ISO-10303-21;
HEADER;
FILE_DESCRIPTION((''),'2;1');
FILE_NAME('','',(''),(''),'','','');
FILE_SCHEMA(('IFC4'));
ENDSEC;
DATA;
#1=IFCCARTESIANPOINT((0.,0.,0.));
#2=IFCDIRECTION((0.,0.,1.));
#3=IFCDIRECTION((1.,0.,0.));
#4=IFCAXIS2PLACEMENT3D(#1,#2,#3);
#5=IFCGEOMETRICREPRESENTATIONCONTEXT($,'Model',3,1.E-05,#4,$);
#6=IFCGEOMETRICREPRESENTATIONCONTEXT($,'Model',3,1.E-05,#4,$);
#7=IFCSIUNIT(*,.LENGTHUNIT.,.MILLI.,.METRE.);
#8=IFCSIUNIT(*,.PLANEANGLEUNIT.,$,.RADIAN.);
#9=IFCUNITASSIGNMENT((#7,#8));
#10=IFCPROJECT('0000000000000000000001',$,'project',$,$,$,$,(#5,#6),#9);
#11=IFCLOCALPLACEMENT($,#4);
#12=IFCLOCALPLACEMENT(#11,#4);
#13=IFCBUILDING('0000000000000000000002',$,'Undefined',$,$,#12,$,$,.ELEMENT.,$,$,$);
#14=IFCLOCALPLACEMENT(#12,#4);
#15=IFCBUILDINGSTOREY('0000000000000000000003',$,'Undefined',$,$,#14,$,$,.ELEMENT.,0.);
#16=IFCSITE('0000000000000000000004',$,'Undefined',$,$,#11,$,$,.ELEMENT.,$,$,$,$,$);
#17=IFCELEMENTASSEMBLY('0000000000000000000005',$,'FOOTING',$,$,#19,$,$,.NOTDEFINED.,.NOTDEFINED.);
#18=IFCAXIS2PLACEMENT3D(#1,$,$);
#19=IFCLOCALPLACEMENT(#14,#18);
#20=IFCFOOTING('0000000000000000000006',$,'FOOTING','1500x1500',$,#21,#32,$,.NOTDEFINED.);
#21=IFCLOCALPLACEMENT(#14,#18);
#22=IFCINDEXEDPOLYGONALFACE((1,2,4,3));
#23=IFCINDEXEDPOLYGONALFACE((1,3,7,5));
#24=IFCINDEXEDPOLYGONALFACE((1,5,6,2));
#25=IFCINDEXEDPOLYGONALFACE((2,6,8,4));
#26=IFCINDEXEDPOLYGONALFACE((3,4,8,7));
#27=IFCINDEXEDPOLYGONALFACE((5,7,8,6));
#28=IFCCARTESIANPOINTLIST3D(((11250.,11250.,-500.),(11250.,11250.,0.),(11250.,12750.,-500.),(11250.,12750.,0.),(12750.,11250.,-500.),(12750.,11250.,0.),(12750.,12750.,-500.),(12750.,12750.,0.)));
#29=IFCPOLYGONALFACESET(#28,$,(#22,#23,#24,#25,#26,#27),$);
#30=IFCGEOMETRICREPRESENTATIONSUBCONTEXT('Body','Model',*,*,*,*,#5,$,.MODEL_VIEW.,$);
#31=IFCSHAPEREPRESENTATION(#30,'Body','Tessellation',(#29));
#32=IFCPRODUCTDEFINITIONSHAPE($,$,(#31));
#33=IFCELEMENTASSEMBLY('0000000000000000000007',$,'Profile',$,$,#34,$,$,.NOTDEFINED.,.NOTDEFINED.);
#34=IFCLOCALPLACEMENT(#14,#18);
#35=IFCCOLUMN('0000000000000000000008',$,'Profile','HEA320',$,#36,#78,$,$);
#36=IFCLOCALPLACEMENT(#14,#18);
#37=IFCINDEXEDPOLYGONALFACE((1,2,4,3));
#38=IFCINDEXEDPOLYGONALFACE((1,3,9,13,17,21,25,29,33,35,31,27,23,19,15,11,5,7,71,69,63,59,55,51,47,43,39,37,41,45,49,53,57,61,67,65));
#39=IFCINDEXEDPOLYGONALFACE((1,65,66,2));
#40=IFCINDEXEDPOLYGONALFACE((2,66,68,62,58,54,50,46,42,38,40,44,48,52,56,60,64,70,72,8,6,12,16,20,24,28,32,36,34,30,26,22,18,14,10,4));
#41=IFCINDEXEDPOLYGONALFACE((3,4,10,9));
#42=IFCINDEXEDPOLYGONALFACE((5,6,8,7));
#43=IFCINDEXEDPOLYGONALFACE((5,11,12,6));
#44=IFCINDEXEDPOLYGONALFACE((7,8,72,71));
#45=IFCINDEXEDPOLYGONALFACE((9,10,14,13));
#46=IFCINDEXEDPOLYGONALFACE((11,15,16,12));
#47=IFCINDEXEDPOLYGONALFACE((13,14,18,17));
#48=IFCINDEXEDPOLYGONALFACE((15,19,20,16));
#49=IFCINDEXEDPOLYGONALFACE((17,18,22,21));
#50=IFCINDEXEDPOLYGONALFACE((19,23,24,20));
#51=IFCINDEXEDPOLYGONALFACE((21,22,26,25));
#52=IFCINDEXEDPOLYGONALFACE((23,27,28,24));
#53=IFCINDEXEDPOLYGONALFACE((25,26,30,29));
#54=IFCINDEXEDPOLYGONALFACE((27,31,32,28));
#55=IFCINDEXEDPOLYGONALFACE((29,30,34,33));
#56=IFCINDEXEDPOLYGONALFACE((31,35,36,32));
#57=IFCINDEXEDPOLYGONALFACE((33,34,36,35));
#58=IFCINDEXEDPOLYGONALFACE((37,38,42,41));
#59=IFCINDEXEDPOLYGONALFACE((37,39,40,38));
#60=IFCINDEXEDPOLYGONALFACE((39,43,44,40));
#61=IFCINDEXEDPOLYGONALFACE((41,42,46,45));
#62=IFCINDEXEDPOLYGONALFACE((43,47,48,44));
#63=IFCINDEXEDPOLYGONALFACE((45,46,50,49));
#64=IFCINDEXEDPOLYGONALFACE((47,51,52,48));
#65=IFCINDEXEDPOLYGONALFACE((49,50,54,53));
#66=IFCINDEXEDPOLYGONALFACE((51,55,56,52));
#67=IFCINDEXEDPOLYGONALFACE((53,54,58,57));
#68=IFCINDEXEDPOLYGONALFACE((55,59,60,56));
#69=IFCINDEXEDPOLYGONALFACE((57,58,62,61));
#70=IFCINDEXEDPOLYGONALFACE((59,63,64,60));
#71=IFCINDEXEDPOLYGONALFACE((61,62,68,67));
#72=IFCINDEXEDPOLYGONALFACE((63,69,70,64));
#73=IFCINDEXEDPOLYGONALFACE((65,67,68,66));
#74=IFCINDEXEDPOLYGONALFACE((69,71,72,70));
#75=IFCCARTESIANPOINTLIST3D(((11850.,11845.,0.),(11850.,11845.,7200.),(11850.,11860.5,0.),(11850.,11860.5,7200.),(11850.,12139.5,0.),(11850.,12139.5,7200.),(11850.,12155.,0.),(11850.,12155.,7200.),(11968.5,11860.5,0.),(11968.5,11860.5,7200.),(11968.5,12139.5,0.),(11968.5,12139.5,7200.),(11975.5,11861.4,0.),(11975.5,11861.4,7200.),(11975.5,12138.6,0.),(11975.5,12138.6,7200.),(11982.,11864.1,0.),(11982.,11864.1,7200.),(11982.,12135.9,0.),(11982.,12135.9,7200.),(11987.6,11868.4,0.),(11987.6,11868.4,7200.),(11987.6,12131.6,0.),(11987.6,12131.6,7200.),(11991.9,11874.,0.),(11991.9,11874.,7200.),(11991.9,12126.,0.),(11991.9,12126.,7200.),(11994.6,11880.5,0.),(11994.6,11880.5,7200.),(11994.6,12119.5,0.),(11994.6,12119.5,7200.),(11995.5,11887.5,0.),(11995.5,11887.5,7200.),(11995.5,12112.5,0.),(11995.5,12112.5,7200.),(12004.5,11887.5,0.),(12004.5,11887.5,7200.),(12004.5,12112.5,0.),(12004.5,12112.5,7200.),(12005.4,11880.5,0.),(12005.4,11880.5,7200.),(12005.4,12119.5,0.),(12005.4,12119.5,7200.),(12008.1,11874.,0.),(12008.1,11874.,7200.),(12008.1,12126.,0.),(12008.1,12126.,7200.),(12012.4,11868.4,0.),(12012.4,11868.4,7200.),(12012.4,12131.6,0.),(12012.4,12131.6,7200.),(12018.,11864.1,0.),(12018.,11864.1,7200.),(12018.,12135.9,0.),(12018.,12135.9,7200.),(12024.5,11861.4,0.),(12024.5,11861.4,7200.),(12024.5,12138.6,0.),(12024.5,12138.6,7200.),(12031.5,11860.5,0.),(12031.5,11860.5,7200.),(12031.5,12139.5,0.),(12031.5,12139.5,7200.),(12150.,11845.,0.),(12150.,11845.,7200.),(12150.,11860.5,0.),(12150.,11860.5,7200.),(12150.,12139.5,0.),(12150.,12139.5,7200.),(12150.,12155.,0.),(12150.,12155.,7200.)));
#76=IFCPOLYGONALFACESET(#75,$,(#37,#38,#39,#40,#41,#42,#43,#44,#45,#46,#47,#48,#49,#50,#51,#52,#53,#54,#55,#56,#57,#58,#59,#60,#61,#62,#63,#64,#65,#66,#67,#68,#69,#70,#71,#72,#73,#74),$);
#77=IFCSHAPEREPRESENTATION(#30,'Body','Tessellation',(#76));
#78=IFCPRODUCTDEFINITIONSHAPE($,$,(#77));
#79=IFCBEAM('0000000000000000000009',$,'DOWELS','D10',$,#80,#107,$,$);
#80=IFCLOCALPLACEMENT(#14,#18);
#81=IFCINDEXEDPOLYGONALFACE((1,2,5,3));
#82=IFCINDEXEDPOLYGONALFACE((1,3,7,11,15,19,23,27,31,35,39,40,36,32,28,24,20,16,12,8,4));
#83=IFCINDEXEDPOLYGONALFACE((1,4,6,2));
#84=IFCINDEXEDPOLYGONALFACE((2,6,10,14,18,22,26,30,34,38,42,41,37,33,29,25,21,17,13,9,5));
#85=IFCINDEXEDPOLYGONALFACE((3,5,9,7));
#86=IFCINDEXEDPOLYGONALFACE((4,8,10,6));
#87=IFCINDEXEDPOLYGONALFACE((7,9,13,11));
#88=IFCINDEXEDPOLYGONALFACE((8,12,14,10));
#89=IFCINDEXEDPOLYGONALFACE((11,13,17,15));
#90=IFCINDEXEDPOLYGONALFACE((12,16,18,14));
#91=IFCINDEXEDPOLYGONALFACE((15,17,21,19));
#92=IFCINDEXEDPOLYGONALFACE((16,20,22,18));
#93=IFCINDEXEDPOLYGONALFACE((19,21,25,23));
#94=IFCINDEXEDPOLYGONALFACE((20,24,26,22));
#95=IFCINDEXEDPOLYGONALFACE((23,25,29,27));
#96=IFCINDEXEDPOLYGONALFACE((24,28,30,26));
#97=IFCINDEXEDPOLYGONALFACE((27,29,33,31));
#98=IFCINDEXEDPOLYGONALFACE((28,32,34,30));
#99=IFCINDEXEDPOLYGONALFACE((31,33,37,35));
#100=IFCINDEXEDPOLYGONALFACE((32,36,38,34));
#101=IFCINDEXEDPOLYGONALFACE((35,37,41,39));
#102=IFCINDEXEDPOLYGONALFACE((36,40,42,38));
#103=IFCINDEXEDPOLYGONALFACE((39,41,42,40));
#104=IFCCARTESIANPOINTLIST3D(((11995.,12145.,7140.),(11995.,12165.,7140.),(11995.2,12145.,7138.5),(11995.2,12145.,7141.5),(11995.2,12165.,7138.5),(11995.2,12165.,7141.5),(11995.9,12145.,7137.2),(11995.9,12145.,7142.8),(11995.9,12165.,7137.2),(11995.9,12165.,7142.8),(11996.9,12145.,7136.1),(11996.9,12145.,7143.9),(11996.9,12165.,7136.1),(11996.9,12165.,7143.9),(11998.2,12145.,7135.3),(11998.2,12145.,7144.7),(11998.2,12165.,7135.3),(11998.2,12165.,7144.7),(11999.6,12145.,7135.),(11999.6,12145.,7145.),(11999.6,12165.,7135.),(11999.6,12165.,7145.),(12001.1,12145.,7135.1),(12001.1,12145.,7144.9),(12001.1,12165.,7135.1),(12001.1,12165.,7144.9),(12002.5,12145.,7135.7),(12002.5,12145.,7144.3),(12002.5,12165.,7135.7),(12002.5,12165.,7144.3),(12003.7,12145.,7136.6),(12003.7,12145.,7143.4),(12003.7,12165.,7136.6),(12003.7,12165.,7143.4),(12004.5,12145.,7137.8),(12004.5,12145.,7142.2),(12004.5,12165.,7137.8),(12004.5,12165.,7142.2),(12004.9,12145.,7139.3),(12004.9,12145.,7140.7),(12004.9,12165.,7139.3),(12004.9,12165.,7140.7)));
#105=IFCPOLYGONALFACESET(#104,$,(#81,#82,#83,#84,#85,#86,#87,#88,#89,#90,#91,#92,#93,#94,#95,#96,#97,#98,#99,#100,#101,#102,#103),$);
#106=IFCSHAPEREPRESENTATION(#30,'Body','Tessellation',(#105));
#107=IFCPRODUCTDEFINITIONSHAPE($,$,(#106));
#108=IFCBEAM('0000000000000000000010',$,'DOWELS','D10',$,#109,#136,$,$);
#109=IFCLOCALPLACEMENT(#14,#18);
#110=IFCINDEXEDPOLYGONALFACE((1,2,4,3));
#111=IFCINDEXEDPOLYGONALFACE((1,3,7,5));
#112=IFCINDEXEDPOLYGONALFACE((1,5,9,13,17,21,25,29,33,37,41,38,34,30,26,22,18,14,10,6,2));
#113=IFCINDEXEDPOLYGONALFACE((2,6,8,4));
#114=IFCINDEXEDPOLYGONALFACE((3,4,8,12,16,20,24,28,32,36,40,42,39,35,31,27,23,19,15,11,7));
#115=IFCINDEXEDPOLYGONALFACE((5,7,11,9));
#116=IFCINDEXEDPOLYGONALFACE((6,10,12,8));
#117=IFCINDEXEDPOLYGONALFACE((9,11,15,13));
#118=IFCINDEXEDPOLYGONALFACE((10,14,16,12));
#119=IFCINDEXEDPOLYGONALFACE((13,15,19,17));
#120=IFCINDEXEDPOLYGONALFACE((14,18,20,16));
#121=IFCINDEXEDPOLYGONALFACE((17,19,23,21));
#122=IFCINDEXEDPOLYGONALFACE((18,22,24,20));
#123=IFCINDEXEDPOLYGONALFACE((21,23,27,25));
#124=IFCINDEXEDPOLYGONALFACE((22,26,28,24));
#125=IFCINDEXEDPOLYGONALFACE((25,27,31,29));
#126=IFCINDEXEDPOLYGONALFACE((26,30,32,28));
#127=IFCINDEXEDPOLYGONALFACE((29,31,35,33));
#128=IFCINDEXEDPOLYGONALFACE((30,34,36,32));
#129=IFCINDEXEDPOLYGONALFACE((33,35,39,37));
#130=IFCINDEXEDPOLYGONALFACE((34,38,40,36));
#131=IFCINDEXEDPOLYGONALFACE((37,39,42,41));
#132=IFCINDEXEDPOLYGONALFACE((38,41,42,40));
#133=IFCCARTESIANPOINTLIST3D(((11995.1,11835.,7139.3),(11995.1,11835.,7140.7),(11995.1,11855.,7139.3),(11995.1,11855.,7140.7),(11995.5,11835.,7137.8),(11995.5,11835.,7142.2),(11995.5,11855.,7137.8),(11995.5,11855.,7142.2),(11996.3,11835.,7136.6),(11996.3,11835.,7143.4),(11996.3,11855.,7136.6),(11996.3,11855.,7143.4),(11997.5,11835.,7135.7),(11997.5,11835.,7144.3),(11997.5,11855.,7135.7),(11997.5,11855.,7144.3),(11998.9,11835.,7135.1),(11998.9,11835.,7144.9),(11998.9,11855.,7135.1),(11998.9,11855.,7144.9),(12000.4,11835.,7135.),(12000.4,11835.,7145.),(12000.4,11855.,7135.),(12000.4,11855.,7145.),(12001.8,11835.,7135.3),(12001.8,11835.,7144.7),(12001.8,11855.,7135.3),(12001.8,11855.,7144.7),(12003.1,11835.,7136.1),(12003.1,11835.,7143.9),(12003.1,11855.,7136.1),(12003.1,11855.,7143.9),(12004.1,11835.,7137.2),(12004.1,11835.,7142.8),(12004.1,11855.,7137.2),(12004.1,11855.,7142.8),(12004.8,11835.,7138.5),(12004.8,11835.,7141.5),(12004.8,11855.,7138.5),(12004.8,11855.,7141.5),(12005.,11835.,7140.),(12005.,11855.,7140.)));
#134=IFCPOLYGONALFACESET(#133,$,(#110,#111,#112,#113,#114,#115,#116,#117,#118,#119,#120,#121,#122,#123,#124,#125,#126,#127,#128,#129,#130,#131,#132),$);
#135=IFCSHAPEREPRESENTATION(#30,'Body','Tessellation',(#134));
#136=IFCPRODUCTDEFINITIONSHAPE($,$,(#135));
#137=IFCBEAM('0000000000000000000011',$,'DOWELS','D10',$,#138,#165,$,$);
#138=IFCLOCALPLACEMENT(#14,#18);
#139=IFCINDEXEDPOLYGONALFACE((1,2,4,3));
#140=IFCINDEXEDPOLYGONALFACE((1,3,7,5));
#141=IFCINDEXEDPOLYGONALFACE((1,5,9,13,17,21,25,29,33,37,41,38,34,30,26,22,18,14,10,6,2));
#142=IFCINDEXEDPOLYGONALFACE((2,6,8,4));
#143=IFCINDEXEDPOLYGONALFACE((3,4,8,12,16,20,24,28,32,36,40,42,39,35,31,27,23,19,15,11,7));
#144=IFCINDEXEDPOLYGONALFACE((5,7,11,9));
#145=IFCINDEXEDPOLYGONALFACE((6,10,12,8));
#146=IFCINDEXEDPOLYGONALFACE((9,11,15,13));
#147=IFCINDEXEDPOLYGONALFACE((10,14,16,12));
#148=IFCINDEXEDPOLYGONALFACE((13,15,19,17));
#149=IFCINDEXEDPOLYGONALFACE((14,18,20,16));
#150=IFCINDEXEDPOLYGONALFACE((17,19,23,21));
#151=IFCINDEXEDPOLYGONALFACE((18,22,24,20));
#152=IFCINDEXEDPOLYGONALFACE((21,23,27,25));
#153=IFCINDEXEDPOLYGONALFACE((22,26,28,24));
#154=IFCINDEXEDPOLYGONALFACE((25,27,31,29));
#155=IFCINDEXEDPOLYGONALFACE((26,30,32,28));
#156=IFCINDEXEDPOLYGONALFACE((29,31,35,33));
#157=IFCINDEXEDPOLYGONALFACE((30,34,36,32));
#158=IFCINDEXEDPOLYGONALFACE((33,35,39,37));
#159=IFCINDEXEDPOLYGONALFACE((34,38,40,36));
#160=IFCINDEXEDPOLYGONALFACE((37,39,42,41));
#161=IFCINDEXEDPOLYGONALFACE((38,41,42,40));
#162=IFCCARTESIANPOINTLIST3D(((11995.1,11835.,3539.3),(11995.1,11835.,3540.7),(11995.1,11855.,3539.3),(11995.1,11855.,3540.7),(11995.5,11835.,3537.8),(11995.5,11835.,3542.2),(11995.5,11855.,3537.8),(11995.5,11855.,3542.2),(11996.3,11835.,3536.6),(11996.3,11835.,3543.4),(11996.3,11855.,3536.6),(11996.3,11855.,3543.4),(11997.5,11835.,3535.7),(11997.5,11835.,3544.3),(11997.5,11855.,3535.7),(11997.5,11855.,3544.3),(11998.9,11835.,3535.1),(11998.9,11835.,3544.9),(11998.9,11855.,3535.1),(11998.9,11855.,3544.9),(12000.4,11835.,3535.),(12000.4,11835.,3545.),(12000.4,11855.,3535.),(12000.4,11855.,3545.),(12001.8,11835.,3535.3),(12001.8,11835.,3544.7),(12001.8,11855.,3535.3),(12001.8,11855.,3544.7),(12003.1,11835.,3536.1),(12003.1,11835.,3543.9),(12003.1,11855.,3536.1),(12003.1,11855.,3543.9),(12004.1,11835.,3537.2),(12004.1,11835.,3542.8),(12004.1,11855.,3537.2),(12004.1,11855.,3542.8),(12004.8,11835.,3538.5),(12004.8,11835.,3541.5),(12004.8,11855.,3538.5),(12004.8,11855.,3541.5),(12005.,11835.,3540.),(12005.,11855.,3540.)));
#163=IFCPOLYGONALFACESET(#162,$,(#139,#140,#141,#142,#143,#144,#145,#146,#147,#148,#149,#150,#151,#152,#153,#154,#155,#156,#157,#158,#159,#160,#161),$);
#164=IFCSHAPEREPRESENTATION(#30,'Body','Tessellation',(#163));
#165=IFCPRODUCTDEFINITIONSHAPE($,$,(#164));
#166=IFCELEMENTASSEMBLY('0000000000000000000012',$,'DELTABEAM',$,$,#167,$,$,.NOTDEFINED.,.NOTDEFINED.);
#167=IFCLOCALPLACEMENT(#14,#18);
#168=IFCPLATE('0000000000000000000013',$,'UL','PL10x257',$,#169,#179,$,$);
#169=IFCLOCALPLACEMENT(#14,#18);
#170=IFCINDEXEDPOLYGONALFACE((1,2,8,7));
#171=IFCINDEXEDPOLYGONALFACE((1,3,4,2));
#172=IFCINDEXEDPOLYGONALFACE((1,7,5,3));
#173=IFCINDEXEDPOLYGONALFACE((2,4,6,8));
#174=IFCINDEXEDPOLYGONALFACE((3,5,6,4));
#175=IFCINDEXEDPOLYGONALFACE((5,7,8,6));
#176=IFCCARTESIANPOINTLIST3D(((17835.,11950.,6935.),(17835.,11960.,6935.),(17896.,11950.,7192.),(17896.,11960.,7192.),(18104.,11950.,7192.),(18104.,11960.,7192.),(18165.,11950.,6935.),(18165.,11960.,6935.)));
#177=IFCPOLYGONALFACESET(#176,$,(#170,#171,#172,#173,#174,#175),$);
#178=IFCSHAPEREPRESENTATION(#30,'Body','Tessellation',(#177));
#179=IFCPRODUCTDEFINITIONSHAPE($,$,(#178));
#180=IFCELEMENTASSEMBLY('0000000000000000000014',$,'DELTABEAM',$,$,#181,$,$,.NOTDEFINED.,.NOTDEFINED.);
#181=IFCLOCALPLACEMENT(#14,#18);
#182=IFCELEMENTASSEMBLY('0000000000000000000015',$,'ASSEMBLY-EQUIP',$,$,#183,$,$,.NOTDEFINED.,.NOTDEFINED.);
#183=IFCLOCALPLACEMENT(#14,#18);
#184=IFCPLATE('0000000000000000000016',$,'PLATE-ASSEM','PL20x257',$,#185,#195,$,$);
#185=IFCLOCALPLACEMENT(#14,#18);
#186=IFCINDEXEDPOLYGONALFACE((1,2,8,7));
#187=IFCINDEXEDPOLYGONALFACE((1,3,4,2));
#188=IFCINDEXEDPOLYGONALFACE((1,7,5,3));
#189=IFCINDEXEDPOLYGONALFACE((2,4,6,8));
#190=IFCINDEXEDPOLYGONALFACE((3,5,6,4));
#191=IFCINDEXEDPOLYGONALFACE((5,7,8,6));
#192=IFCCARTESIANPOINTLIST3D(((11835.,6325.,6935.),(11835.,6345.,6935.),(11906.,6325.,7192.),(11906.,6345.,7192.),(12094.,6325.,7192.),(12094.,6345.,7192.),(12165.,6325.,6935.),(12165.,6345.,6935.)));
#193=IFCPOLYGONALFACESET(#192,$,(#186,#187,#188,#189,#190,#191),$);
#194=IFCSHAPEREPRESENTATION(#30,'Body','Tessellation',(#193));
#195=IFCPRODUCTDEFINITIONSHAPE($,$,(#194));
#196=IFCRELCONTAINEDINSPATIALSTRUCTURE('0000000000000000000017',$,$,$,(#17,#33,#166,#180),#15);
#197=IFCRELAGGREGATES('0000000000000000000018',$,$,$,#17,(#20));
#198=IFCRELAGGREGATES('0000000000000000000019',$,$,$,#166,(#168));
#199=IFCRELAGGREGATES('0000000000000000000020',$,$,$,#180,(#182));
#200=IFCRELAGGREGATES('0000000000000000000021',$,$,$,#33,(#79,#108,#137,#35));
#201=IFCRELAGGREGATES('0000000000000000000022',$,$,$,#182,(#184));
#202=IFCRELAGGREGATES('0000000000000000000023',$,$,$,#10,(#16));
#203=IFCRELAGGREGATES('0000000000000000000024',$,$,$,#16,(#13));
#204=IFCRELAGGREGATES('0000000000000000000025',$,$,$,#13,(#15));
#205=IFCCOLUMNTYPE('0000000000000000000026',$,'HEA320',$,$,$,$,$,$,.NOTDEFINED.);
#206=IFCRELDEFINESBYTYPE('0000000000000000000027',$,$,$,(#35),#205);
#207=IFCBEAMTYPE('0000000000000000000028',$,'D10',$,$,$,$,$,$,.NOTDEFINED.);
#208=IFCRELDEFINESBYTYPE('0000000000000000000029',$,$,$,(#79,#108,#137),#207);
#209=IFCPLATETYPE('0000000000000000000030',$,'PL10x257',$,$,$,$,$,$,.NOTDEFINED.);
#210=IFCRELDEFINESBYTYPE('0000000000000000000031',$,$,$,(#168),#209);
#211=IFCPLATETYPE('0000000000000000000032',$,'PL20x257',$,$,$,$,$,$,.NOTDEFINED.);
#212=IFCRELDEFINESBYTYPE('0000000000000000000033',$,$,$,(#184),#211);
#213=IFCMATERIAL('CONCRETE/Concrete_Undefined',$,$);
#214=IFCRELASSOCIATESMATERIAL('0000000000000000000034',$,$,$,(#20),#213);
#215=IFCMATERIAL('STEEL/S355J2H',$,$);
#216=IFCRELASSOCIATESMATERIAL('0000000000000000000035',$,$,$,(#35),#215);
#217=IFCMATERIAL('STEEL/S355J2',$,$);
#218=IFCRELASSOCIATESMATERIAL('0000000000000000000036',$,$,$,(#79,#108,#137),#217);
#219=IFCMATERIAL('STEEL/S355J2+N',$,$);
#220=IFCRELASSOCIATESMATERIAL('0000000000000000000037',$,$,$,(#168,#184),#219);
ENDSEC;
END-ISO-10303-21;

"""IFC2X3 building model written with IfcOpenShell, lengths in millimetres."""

from ifc_helpers import new_model, si_unit, frame, origin_with_axes, origin_2d_with_axis, place, context, subcontext, project, spatial, polyline, rectangle, circle, i_section, outline, extrude, material, type_object, element, aggregate, save


model = new_model("IFC2X3")

# Units and contexts
model_context_1 = context("Model", 3, precision=1e-05, world=origin_with_axes())
model_context_2 = context("Model", 3, precision=1e-05, world=origin_with_axes())
body_context = subcontext(model_context_1, "Body", "Model", "MODEL_VIEW")
ifc_project = project(units=[si_unit("LENGTHUNIT", "METRE", prefix="MILLI"), si_unit("PLANEANGLEUNIT", "RADIAN")], contexts=[model_context_1, model_context_2])

# Site, building, storey
site_placement = place(None, origin_with_axes())
site = spatial("IfcSite", under=ifc_project, at=site_placement, Name="Undefined", CompositionType="ELEMENT")
building_placement = place(site_placement, origin_with_axes())
building = spatial("IfcBuilding", under=site, at=building_placement, Name="Undefined", CompositionType="ELEMENT")
storey_placement = place(building_placement, origin_with_axes())
storey = spatial("IfcBuildingStorey", under=building, at=storey_placement, Name="Undefined", CompositionType="ELEMENT", Elevation=0.0)

# Element assembly, footing
assembly_1_placement = place(storey_placement, origin_with_axes())
assembly_1 = element("IfcElementAssembly", 1, at=assembly_1_placement, inside=storey, Name="FOOTING", AssemblyPlace="NOTDEFINED", PredefinedType="NOTDEFINED")
ifc_material_1 = material(Name="CONCRETE/Concrete_Undefined")
footing_placement = place(assembly_1_placement, frame((12000.0, 12000.0, -500.0), z_axis=(0.0, 1.0, 0.0), x_axis=(0.0, 0.0, 1.0)))
footing = element("IfcFooting", 2, at=footing_placement, material=ifc_material_1, Name="FOOTING", Description="1500x1500", PredefinedType="NOTDEFINED", context=body_context, shape_type="SweptSolid", body=[
    extrude(rectangle(XDim=1500.0, YDim=1500.0, at=origin_2d_with_axis()), frame((500.0, 0.0, 0.0), z_axis=(-1.0, 0.0, 0.0), x_axis=(0.0, -1.0, 0.0)), (0.0, 0.0, 1.0), 500.0),
])
aggregate(assembly_1, [footing])

# Element assembly, column, beams
assembly_2_placement = place(storey_placement, origin_with_axes())
assembly_2 = element("IfcElementAssembly", 3, at=assembly_2_placement, inside=storey, Name="Profile", AssemblyPlace="NOTDEFINED", PredefinedType="NOTDEFINED")
ifc_material_2 = material(Name="STEEL/S355J2H")
column_type = type_object("IfcColumnType", Name="HEA320", PredefinedType="NOTDEFINED")
column_placement = place(assembly_2_placement, frame((12000.0, 12000.0, 0.0), z_axis=(0.0, 0.0, 1.0), x_axis=(0.0, 1.0, 0.0)))
column = element("IfcColumn", 4, at=column_placement, type_object=column_type, material=ifc_material_2, Name="Profile", Description="HEA320", context=body_context, shape_type="SweptSolid", body=[
    extrude(i_section(OverallWidth=300.0, OverallDepth=310.0, WebThickness=9.0, FlangeThickness=15.5, FilletRadius=27.0, at=origin_2d_with_axis()), frame((0.0, 0.0, 7200.0), z_axis=(0.0, 0.0, -1.0), x_axis=(0.0, 1.0, 0.0)), (0.0, 0.0, 1.0), 7200.0),
])
ifc_material_3 = material(Name="STEEL/S355J2")
beam_type_1 = type_object("IfcBeamType", Name="D10", PredefinedType="NOTDEFINED")
beam_1_placement = place(assembly_2_placement, frame((12000.0, 12165.0, 7140.0), z_axis=(0.0, 0.0, 1.0), x_axis=(0.0, -1.0, 0.0)))
beam_1 = element("IfcBeam", 5, at=beam_1_placement, type_object=beam_type_1, material=ifc_material_3, Name="DOWELS", Description="D10", context=body_context, shape_type="SweptSolid", body=[
    extrude(circle(Radius=5.0, at=origin_2d_with_axis()), frame((20.0, 0.0, 0.0), z_axis=(-1.0, 0.0, 0.0), x_axis=(0.0, -1.0, 0.0)), (0.0, 0.0, 1.0), 20.0),
])
beam_2_placement = place(assembly_2_placement, frame((12000.0, 11835.0, 7140.0), z_axis=(0.0, 0.0, 1.0), x_axis=(0.0, 1.0, 0.0)))
beam_2 = element("IfcBeam", 6, at=beam_2_placement, type_object=beam_type_1, material=ifc_material_3, Name="DOWELS", Description="D10", context=body_context, shape_type="SweptSolid", body=[
    extrude(circle(Radius=5.0, at=origin_2d_with_axis()), frame((20.0, 0.0, 0.0), z_axis=(-1.0, 0.0, 0.0), x_axis=(0.0, -1.0, 0.0)), (0.0, 0.0, 1.0), 20.0),
])
beam_3_placement = place(assembly_2_placement, frame((12000.0, 11835.0, 3540.0), z_axis=(0.0, 0.0, 1.0), x_axis=(0.0, 1.0, 0.0)))
beam_3 = element("IfcBeam", 7, at=beam_3_placement, type_object=beam_type_1, material=ifc_material_3, Name="DOWELS", Description="D10", context=body_context, shape_type="SweptSolid", body=[
    extrude(circle(Radius=5.0, at=origin_2d_with_axis()), frame((20.0, 0.0, 0.0), z_axis=(-1.0, 0.0, 0.0), x_axis=(0.0, -1.0, 0.0)), (0.0, 0.0, 1.0), 20.0),
])

# Element assembly, plate
assembly_3_placement = place(storey_placement, origin_with_axes())
assembly_3 = element("IfcElementAssembly", 8, at=assembly_3_placement, inside=storey, Name="DELTABEAM", AssemblyPlace="NOTDEFINED", PredefinedType="NOTDEFINED")
ifc_material_4 = material(Name="STEEL/S355J2+N")
plate_type_1 = type_object("IfcPlateType", Name="PL10x257", PredefinedType="NOTDEFINED")
plate_1_placement = place(assembly_3_placement, frame((17835.0, 11955.0, 6935.0), z_axis=(0.0, -1.0, 0.0), x_axis=(1.0, 0.0, 0.0)))
plate_1 = element("IfcPlate", 9, at=plate_1_placement, type_object=plate_type_1, material=ifc_material_4, Name="UL", Description="PL10x257", context=body_context, shape_type="SweptSolid", body=[
    extrude(outline(polyline([(0.0, 0.0), (330.0, 0.0), (269.0, 257.0), (61.0, 257.0), (0.0, 0.0)])), frame((0.0, 0.0, -5.0), z_axis=(0.0, 0.0, 1.0), x_axis=(1.0, 0.0, 0.0)), (0.0, 0.0, 1.0), 10.0),
])
aggregate(assembly_3, [plate_1])

# Element assemblies, plate
assembly_4_placement = place(storey_placement, origin_with_axes())
assembly_4 = element("IfcElementAssembly", 10, at=assembly_4_placement, inside=storey, Name="DELTABEAM", AssemblyPlace="NOTDEFINED", PredefinedType="NOTDEFINED")
assembly_5_placement = place(assembly_4_placement, origin_with_axes())
assembly_5 = element("IfcElementAssembly", 11, at=assembly_5_placement, Name="ASSEMBLY-EQUIP", AssemblyPlace="NOTDEFINED", PredefinedType="NOTDEFINED")
plate_type_2 = type_object("IfcPlateType", Name="PL20x257", PredefinedType="NOTDEFINED")
plate_2_placement = place(assembly_5_placement, frame((12165.0, 6335.0, 6935.0), z_axis=(0.0, 1.0, 0.0), x_axis=(-1.0, 0.0, 0.0)))
plate_2 = element("IfcPlate", 12, at=plate_2_placement, type_object=plate_type_2, material=ifc_material_4, Name="PLATE-ASSEM", Description="PL20x257", context=body_context, shape_type="SweptSolid", body=[
    extrude(outline(polyline([(0.0, 0.0), (330.0, 0.0), (259.0, 257.0), (71.0, 257.0), (0.0, 0.0)])), frame((0.0, 0.0, -10.0), z_axis=(0.0, 0.0, 1.0), x_axis=(1.0, 0.0, 0.0)), (0.0, 0.0, 1.0), 20.0),
])

aggregate(assembly_4, [assembly_5])

aggregate(assembly_2, [beam_1, beam_2, beam_3, column])

aggregate(assembly_5, [plate_2])

save(model, "model.ifc")
